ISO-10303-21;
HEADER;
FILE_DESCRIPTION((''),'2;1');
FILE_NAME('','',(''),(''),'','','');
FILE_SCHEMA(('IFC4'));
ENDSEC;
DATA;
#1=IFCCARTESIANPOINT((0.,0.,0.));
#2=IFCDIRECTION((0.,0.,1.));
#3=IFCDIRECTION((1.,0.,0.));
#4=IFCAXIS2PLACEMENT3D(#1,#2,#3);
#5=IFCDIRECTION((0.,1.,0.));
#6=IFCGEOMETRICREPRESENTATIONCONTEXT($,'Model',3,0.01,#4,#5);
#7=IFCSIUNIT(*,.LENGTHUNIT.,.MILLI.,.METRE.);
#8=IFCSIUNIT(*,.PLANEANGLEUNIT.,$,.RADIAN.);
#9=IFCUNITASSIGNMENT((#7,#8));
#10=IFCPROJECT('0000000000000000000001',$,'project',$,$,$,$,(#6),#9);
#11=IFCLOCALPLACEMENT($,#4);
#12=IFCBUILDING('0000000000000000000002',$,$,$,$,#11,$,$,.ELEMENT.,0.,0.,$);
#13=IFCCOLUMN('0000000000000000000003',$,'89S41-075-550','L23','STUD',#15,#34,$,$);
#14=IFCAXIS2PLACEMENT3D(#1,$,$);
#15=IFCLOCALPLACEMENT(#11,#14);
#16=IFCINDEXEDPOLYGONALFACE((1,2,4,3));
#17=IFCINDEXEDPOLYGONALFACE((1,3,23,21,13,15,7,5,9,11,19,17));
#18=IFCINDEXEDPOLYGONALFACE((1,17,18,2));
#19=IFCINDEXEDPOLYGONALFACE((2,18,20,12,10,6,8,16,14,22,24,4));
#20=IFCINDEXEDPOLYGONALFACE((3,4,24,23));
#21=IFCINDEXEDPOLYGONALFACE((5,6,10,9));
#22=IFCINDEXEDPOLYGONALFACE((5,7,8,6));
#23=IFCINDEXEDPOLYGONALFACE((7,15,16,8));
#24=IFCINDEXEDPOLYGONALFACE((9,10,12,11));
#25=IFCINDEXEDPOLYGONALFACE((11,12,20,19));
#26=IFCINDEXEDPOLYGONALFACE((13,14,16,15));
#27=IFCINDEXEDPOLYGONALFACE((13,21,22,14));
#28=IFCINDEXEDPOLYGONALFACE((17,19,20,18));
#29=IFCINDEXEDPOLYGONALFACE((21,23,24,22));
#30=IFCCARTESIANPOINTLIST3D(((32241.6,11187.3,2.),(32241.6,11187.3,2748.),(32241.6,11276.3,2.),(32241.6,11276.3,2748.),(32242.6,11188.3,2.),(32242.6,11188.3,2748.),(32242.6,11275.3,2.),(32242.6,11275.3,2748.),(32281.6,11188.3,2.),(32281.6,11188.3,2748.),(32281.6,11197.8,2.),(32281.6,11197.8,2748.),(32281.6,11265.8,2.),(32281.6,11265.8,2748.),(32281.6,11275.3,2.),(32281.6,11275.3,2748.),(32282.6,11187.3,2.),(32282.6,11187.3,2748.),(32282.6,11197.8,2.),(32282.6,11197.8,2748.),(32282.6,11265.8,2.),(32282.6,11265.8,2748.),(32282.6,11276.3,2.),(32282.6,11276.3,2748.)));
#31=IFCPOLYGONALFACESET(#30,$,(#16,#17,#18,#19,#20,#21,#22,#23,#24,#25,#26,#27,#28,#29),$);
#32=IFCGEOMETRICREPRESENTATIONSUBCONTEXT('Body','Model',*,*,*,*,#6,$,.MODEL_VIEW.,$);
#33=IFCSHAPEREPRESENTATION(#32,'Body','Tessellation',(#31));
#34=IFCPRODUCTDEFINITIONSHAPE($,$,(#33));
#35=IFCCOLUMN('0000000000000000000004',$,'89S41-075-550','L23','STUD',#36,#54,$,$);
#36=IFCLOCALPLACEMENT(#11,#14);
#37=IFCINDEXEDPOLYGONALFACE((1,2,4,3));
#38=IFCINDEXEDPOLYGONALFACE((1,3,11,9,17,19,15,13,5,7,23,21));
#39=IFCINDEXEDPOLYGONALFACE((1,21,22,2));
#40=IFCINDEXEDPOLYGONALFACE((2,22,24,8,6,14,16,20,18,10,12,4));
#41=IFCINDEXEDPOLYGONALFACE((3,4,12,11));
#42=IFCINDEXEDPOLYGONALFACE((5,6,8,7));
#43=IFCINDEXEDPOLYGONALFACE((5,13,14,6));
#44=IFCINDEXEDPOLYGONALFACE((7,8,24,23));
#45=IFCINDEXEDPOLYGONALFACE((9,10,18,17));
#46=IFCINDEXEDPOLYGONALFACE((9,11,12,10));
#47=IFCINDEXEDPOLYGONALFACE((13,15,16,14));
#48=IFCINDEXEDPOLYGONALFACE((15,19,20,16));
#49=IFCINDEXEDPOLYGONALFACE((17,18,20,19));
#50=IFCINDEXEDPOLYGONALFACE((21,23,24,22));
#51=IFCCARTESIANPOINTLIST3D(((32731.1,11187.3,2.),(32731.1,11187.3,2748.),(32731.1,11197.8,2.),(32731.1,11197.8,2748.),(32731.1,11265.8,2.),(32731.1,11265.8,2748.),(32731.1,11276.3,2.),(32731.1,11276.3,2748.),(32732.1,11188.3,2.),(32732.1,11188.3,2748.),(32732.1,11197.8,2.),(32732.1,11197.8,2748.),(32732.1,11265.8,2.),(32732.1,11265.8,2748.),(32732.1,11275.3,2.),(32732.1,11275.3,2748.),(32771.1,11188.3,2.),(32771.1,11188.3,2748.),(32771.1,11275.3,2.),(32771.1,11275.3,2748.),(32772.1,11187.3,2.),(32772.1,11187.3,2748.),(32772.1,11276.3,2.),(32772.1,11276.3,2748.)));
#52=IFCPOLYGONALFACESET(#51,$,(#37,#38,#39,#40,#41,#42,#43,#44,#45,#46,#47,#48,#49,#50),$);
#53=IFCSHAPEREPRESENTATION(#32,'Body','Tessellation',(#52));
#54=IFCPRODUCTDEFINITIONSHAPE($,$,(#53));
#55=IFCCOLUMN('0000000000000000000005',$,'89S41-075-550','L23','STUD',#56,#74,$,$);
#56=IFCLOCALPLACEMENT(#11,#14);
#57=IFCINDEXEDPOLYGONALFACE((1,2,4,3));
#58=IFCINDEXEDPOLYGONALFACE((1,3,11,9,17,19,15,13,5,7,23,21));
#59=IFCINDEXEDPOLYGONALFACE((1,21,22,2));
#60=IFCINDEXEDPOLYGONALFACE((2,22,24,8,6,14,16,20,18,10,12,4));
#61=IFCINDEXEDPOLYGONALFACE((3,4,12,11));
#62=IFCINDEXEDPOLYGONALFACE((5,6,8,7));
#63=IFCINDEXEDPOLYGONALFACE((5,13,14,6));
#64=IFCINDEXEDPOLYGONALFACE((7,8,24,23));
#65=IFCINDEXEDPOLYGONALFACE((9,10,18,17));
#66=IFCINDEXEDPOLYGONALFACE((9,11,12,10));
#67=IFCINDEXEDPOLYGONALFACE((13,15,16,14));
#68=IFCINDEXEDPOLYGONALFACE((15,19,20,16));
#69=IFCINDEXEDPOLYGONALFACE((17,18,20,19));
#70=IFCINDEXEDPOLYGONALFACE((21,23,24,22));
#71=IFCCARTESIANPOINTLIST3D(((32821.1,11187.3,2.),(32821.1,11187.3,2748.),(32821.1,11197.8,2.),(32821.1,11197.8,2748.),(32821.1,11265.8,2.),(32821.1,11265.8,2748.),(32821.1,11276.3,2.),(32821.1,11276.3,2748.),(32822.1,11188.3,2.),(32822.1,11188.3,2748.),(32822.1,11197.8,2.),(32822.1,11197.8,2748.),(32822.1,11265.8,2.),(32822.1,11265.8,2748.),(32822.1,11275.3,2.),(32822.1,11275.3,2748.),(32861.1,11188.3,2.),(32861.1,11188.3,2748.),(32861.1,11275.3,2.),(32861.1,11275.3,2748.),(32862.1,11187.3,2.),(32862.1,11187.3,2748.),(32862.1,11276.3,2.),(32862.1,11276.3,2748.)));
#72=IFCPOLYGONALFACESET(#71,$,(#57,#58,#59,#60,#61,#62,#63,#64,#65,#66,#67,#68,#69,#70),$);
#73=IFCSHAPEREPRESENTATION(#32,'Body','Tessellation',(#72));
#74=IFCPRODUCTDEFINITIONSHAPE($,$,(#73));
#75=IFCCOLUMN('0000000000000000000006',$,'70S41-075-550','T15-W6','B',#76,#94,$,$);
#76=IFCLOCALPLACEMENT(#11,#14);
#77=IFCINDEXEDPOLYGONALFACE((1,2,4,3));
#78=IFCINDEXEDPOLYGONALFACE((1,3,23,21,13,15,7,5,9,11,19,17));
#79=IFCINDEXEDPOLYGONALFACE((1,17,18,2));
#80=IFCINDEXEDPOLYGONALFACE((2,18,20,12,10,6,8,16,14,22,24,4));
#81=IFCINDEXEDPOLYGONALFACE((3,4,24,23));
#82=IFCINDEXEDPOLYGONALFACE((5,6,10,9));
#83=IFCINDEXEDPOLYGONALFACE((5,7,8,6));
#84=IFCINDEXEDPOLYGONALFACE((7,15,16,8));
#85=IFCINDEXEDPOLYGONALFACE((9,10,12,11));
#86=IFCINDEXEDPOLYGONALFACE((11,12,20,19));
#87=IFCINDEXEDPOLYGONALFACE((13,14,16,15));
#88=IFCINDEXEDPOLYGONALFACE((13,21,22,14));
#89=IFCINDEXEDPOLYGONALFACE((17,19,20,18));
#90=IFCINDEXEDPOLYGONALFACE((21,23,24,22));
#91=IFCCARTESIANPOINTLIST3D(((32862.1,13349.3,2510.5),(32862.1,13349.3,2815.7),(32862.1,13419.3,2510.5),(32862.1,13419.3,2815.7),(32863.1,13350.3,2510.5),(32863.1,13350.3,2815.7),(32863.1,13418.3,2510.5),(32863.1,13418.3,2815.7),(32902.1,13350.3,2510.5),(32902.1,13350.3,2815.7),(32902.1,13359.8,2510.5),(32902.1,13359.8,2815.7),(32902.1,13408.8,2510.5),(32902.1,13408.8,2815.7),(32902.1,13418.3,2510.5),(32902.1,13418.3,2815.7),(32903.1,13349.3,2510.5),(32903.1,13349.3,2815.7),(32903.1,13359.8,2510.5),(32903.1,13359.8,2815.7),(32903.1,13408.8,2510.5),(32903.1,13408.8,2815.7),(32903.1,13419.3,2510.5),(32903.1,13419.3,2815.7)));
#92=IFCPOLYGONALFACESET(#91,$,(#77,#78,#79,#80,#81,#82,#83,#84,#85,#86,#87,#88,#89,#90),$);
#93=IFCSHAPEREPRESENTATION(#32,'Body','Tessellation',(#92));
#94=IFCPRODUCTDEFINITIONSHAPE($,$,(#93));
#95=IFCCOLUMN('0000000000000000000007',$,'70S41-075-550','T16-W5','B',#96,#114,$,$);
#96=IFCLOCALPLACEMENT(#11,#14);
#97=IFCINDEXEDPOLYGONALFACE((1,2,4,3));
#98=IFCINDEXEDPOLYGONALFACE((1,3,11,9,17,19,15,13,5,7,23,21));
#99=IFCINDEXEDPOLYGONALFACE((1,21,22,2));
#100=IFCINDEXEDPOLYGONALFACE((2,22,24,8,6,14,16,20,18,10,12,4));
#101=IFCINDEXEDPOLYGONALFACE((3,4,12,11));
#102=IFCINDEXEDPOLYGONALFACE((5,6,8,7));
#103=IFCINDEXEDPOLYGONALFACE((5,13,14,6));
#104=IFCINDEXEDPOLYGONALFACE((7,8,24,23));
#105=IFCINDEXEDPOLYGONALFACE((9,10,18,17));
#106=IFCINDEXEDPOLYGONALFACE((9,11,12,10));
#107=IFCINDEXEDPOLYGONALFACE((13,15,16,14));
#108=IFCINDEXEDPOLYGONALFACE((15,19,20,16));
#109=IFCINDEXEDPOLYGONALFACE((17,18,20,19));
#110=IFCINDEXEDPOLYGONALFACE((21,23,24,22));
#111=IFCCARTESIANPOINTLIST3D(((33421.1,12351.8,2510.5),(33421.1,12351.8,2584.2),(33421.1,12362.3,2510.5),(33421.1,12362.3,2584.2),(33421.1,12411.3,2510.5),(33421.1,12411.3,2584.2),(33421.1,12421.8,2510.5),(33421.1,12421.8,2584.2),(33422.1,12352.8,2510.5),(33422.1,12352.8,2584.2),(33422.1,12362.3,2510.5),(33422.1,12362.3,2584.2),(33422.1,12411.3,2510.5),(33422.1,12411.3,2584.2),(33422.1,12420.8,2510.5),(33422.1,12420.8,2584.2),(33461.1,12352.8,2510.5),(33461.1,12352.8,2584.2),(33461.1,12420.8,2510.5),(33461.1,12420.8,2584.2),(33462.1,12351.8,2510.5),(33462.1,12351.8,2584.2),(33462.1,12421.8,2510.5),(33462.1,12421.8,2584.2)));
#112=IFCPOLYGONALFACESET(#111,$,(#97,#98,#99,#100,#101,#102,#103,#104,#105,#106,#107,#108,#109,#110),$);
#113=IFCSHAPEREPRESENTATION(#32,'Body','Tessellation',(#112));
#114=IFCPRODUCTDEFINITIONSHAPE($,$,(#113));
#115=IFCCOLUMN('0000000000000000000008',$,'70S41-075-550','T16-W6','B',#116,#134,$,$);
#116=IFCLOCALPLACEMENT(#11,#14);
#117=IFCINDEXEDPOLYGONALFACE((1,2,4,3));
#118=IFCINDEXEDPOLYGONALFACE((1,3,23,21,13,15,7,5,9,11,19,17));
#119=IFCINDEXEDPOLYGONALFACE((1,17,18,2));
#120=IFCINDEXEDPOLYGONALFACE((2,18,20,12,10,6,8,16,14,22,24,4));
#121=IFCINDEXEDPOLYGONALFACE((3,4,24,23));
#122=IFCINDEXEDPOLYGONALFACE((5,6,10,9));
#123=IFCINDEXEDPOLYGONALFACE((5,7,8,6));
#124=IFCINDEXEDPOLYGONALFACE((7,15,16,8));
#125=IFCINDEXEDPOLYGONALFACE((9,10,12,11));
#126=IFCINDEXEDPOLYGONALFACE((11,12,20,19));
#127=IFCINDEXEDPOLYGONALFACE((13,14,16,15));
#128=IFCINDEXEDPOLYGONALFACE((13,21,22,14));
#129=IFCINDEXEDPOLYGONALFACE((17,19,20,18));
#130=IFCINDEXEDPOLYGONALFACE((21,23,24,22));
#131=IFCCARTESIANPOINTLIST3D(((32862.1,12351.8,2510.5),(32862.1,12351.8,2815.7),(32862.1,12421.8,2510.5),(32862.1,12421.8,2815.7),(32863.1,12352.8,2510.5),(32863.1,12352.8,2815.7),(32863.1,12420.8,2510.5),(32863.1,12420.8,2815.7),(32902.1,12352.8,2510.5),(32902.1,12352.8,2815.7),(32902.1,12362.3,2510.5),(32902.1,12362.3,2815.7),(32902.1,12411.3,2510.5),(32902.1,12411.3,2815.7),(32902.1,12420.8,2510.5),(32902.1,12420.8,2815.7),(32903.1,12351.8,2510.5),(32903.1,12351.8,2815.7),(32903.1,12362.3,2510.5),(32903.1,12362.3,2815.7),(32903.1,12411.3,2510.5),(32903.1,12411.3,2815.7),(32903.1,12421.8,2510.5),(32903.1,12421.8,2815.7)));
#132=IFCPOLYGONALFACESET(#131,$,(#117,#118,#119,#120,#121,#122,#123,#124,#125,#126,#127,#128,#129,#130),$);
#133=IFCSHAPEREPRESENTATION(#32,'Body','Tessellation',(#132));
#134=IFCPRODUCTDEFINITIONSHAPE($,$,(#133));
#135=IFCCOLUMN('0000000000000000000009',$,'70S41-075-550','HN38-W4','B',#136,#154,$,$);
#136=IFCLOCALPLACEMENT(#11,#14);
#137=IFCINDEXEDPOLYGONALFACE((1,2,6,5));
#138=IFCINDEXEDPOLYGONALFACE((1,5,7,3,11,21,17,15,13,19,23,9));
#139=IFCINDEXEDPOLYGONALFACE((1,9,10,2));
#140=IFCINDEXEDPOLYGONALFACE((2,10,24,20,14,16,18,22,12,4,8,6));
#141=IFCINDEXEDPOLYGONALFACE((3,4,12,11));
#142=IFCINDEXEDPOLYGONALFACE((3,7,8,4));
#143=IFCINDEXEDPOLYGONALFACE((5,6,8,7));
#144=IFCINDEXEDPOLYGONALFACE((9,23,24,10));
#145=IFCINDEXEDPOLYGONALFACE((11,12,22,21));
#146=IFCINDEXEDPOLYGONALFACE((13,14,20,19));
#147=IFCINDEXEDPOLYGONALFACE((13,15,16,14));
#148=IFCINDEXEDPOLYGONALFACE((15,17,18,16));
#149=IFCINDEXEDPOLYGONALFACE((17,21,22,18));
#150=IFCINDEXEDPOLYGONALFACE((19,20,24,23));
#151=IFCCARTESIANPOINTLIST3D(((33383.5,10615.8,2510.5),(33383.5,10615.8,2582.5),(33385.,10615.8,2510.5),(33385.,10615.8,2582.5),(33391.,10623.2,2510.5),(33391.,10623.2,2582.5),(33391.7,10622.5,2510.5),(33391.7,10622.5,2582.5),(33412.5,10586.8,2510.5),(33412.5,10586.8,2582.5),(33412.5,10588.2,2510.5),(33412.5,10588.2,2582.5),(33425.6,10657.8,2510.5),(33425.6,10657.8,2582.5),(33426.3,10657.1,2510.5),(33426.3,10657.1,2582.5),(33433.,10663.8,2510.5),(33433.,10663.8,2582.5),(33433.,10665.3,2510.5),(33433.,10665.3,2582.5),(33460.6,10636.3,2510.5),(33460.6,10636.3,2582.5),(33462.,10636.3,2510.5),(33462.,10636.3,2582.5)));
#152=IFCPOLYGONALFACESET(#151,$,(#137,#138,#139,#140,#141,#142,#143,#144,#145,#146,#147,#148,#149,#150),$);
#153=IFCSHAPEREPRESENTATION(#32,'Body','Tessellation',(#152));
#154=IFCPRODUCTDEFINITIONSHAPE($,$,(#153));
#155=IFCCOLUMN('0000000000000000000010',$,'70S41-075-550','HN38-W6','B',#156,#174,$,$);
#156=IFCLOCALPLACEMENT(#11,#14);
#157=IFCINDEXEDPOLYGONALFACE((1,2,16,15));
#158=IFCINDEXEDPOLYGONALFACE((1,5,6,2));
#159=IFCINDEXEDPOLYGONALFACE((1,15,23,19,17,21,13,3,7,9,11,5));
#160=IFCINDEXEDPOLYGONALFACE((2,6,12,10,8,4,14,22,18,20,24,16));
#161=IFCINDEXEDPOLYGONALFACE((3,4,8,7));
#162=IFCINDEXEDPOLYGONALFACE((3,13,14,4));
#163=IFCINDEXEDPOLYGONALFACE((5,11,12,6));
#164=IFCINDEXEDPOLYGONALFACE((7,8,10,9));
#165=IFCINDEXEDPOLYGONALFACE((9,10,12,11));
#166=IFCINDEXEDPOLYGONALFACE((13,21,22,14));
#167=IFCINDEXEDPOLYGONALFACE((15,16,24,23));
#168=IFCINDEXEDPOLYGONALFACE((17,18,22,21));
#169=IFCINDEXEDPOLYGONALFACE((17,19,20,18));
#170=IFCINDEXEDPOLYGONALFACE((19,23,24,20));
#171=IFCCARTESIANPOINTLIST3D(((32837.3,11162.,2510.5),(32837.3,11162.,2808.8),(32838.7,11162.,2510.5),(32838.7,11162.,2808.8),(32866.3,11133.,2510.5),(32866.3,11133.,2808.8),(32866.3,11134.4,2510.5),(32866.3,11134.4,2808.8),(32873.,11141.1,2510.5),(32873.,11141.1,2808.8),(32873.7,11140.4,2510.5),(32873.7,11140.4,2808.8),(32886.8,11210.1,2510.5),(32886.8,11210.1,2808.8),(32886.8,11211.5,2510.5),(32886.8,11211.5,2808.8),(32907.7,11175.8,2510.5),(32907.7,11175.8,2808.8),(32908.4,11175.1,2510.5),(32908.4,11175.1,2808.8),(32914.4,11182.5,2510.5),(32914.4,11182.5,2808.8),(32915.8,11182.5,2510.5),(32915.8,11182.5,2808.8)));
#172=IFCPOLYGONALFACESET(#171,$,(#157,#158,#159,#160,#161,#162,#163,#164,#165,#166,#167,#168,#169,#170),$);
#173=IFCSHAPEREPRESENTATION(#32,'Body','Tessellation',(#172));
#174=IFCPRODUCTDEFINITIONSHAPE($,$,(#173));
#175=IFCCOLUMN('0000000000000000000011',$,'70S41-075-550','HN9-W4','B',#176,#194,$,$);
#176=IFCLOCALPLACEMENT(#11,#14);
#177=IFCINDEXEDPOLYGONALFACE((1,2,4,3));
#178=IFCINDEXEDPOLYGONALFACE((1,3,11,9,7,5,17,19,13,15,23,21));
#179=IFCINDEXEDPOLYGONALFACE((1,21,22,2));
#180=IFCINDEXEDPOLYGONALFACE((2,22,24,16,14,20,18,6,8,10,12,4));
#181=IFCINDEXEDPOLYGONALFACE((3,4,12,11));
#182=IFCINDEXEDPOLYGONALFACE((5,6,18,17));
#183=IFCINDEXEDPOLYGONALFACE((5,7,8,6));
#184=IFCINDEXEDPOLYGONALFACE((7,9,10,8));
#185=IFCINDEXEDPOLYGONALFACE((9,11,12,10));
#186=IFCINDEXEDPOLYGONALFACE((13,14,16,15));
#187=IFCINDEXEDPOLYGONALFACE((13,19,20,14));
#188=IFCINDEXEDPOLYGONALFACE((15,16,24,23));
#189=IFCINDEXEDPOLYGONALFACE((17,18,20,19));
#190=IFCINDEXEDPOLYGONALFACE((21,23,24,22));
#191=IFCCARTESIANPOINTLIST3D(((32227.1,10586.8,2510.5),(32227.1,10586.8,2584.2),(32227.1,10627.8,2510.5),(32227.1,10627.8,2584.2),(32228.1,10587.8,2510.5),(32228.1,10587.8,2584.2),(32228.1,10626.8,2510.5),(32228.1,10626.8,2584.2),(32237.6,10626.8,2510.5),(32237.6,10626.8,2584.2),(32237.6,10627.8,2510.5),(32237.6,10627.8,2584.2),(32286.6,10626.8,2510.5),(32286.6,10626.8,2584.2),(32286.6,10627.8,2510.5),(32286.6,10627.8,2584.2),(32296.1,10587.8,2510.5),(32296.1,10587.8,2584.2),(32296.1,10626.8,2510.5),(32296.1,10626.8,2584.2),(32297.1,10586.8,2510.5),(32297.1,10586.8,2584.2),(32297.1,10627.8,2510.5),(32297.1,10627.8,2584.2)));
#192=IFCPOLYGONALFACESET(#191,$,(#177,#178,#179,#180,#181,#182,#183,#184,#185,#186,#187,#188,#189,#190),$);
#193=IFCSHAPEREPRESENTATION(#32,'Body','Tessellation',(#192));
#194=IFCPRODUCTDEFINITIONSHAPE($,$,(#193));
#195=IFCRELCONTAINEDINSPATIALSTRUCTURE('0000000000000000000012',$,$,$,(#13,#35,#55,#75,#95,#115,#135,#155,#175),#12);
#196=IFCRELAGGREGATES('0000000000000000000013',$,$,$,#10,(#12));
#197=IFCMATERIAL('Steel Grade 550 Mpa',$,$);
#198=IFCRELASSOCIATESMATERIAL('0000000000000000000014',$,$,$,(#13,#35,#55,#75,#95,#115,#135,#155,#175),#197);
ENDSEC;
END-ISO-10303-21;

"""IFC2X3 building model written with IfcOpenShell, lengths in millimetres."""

from ifc_helpers import new_model, si_unit, direction, frame, origin, origin_with_axes, origin_2d_with_axis, place, context, subcontext, project, spatial, c_section, extrude, source, transform, mapped, material, element, save


model = new_model("IFC2X3")

# Units and contexts
model_context = context("Model", 3, precision=0.01, world=origin_with_axes(), true_north=direction((0.0, 1.0, 0.0)))
body_context = subcontext(model_context, "Body", "Model", "MODEL_VIEW")
ifc_project = project(units=[si_unit("LENGTHUNIT", "METRE", prefix="MILLI"), si_unit("PLANEANGLEUNIT", "RADIAN")], contexts=[model_context])

# Building
building_placement = place(None, origin_with_axes())
building = spatial("IfcBuilding", under=ifc_project, at=building_placement, CompositionType="ELEMENT", ElevationOfRefHeight=0.0, ElevationOfTerrain=0.0)

# Columns
ifc_material = material(Name="Steel Grade 550 Mpa")
shared_shape_1 = source(origin(), body_context, "Body", "SweptSolid", [
    extrude(c_section(Depth=89.0, Width=41.0, WallThickness=1.0, Girth=10.5, at=origin_2d_with_axis()), origin_with_axes(), (0.0, 0.0, 1.0), 2746.0),
])
column_1_placement = place(None, frame((32262.1, 11231.8, 2.0), z_axis=(0.0, 0.0, 1.0), x_axis=(1.0, 0.0, 0.0)))
element("IfcColumn", 1, at=column_1_placement, inside=building, material=ifc_material, Name="89S41-075-550", Description="L23", ObjectType="STUD", context=body_context, shape_type="MappedRepresentation", body=[
    mapped(shared_shape_1, transform((0.0, 0.0, 0.0), scale=1.0)),
])
shared_shape_2 = source(origin(), body_context, "Body", "SweptSolid", [
    extrude(c_section(Depth=89.0, Width=41.0, WallThickness=1.0, Girth=10.5, at=origin_2d_with_axis()), origin_with_axes(), (0.0, 0.0, 1.0), 2746.0),
])
column_2_placement = place(None, frame((32751.6, 11231.8, 2.0), z_axis=(0.0, 0.0, 1.0), x_axis=(-1.0, 0.0, 0.0)))
element("IfcColumn", 2, at=column_2_placement, inside=building, material=ifc_material, Name="89S41-075-550", Description="L23", ObjectType="STUD", context=body_context, shape_type="MappedRepresentation", body=[
    mapped(shared_shape_2, transform((0.0, 0.0, 0.0), scale=1.0)),
])
shared_shape_3 = source(origin(), body_context, "Body", "SweptSolid", [
    extrude(c_section(Depth=89.0, Width=41.0, WallThickness=1.0, Girth=10.5, at=origin_2d_with_axis()), origin_with_axes(), (0.0, 0.0, 1.0), 2746.0),
])
column_3_placement = place(None, frame((32841.6, 11231.8, 2.0), z_axis=(0.0, 0.0, 1.0), x_axis=(-1.0, 0.0, 0.0)))
element("IfcColumn", 3, at=column_3_placement, inside=building, material=ifc_material, Name="89S41-075-550", Description="L23", ObjectType="STUD", context=body_context, shape_type="MappedRepresentation", body=[
    mapped(shared_shape_3, transform((0.0, 0.0, 0.0), scale=1.0)),
])
shared_shape_4 = source(origin(), body_context, "Body", "SweptSolid", [
    extrude(c_section(Depth=70.0, Width=41.0, WallThickness=1.0, Girth=10.5, at=origin_2d_with_axis()), origin_with_axes(), (0.0, 0.0, 1.0), 305.2),
])
column_4_placement = place(None, frame((32882.6, 13384.3, 2510.5), z_axis=(0.0, 0.0, 1.0), x_axis=(1.0, 0.0, 0.0)))
element("IfcColumn", 4, at=column_4_placement, inside=building, material=ifc_material, Name="70S41-075-550", Description="T15-W6", ObjectType="B", context=body_context, shape_type="MappedRepresentation", body=[
    mapped(shared_shape_4, transform((0.0, 0.0, 0.0), scale=1.0)),
])
shared_shape_5 = source(origin(), body_context, "Body", "SweptSolid", [
    extrude(c_section(Depth=70.0, Width=41.0, WallThickness=1.0, Girth=10.5, at=origin_2d_with_axis()), origin_with_axes(), (0.0, 0.0, 1.0), 73.7),
])
column_5_placement = place(None, frame((33441.6, 12386.8, 2584.2), z_axis=(0.0, 0.0, -1.0), x_axis=(-1.0, 0.0, 0.0)))
element("IfcColumn", 5, at=column_5_placement, inside=building, material=ifc_material, Name="70S41-075-550", Description="T16-W5", ObjectType="B", context=body_context, shape_type="MappedRepresentation", body=[
    mapped(shared_shape_5, transform((0.0, 0.0, 0.0), scale=1.0)),
])
shared_shape_6 = source(origin(), body_context, "Body", "SweptSolid", [
    extrude(c_section(Depth=70.0, Width=41.0, WallThickness=1.0, Girth=10.5, at=origin_2d_with_axis()), origin_with_axes(), (0.0, 0.0, 1.0), 305.2),
])
column_6_placement = place(None, frame((32882.6, 12386.8, 2510.5), z_axis=(0.0, 0.0, 1.0), x_axis=(1.0, 0.0, 0.0)))
element("IfcColumn", 6, at=column_6_placement, inside=building, material=ifc_material, Name="70S41-075-550", Description="T16-W6", ObjectType="B", context=body_context, shape_type="MappedRepresentation", body=[
    mapped(shared_shape_6, transform((0.0, 0.0, 0.0), scale=1.0)),
])
shared_shape_7 = source(origin(), body_context, "Body", "SweptSolid", [
    extrude(c_section(Depth=70.0, Width=41.0, WallThickness=1.0, Girth=10.5, at=origin_2d_with_axis()), origin_with_axes(), (0.0, 0.0, 1.0), 72.0),
])
column_7_placement = place(None, frame((33422.8, 10626.0, 2582.5), z_axis=(0.0, 0.0, -1.0), x_axis=(-0.707107, 0.707107, 0.0)))
element("IfcColumn", 7, at=column_7_placement, inside=building, material=ifc_material, Name="70S41-075-550", Description="HN38-W4", ObjectType="B", context=body_context, shape_type="MappedRepresentation", body=[
    mapped(shared_shape_7, transform((0.0, 0.0, 0.0), scale=1.0)),
])
shared_shape_8 = source(origin(), body_context, "Body", "SweptSolid", [
    extrude(c_section(Depth=70.0, Width=41.0, WallThickness=1.0, Girth=10.5, at=origin_2d_with_axis()), origin_with_axes(), (0.0, 0.0, 1.0), 298.3),
])
column_8_placement = place(None, frame((32876.5, 11172.3, 2510.5), z_axis=(0.0, 0.0, 1.0), x_axis=(0.707107, -0.707107, 0.0)))
element("IfcColumn", 8, at=column_8_placement, inside=building, material=ifc_material, Name="70S41-075-550", Description="HN38-W6", ObjectType="B", context=body_context, shape_type="MappedRepresentation", body=[
    mapped(shared_shape_8, transform((0.0, 0.0, 0.0), scale=1.0)),
])
shared_shape_9 = source(origin(), body_context, "Body", "SweptSolid", [
    extrude(c_section(Depth=70.0, Width=41.0, WallThickness=1.0, Girth=10.5, at=origin_2d_with_axis()), origin_with_axes(), (0.0, 0.0, 1.0), 73.7),
])
column_9_placement = place(None, frame((32262.1, 10607.3, 2584.2), z_axis=(0.0, 0.0, -1.0), x_axis=(0.0, 1.0, 0.0)))
element("IfcColumn", 9, at=column_9_placement, inside=building, material=ifc_material, Name="70S41-075-550", Description="HN9-W4", ObjectType="B", context=body_context, shape_type="MappedRepresentation", body=[
    mapped(shared_shape_9, transform((0.0, 0.0, 0.0), scale=1.0)),
])

save(model, "model.ifc")
